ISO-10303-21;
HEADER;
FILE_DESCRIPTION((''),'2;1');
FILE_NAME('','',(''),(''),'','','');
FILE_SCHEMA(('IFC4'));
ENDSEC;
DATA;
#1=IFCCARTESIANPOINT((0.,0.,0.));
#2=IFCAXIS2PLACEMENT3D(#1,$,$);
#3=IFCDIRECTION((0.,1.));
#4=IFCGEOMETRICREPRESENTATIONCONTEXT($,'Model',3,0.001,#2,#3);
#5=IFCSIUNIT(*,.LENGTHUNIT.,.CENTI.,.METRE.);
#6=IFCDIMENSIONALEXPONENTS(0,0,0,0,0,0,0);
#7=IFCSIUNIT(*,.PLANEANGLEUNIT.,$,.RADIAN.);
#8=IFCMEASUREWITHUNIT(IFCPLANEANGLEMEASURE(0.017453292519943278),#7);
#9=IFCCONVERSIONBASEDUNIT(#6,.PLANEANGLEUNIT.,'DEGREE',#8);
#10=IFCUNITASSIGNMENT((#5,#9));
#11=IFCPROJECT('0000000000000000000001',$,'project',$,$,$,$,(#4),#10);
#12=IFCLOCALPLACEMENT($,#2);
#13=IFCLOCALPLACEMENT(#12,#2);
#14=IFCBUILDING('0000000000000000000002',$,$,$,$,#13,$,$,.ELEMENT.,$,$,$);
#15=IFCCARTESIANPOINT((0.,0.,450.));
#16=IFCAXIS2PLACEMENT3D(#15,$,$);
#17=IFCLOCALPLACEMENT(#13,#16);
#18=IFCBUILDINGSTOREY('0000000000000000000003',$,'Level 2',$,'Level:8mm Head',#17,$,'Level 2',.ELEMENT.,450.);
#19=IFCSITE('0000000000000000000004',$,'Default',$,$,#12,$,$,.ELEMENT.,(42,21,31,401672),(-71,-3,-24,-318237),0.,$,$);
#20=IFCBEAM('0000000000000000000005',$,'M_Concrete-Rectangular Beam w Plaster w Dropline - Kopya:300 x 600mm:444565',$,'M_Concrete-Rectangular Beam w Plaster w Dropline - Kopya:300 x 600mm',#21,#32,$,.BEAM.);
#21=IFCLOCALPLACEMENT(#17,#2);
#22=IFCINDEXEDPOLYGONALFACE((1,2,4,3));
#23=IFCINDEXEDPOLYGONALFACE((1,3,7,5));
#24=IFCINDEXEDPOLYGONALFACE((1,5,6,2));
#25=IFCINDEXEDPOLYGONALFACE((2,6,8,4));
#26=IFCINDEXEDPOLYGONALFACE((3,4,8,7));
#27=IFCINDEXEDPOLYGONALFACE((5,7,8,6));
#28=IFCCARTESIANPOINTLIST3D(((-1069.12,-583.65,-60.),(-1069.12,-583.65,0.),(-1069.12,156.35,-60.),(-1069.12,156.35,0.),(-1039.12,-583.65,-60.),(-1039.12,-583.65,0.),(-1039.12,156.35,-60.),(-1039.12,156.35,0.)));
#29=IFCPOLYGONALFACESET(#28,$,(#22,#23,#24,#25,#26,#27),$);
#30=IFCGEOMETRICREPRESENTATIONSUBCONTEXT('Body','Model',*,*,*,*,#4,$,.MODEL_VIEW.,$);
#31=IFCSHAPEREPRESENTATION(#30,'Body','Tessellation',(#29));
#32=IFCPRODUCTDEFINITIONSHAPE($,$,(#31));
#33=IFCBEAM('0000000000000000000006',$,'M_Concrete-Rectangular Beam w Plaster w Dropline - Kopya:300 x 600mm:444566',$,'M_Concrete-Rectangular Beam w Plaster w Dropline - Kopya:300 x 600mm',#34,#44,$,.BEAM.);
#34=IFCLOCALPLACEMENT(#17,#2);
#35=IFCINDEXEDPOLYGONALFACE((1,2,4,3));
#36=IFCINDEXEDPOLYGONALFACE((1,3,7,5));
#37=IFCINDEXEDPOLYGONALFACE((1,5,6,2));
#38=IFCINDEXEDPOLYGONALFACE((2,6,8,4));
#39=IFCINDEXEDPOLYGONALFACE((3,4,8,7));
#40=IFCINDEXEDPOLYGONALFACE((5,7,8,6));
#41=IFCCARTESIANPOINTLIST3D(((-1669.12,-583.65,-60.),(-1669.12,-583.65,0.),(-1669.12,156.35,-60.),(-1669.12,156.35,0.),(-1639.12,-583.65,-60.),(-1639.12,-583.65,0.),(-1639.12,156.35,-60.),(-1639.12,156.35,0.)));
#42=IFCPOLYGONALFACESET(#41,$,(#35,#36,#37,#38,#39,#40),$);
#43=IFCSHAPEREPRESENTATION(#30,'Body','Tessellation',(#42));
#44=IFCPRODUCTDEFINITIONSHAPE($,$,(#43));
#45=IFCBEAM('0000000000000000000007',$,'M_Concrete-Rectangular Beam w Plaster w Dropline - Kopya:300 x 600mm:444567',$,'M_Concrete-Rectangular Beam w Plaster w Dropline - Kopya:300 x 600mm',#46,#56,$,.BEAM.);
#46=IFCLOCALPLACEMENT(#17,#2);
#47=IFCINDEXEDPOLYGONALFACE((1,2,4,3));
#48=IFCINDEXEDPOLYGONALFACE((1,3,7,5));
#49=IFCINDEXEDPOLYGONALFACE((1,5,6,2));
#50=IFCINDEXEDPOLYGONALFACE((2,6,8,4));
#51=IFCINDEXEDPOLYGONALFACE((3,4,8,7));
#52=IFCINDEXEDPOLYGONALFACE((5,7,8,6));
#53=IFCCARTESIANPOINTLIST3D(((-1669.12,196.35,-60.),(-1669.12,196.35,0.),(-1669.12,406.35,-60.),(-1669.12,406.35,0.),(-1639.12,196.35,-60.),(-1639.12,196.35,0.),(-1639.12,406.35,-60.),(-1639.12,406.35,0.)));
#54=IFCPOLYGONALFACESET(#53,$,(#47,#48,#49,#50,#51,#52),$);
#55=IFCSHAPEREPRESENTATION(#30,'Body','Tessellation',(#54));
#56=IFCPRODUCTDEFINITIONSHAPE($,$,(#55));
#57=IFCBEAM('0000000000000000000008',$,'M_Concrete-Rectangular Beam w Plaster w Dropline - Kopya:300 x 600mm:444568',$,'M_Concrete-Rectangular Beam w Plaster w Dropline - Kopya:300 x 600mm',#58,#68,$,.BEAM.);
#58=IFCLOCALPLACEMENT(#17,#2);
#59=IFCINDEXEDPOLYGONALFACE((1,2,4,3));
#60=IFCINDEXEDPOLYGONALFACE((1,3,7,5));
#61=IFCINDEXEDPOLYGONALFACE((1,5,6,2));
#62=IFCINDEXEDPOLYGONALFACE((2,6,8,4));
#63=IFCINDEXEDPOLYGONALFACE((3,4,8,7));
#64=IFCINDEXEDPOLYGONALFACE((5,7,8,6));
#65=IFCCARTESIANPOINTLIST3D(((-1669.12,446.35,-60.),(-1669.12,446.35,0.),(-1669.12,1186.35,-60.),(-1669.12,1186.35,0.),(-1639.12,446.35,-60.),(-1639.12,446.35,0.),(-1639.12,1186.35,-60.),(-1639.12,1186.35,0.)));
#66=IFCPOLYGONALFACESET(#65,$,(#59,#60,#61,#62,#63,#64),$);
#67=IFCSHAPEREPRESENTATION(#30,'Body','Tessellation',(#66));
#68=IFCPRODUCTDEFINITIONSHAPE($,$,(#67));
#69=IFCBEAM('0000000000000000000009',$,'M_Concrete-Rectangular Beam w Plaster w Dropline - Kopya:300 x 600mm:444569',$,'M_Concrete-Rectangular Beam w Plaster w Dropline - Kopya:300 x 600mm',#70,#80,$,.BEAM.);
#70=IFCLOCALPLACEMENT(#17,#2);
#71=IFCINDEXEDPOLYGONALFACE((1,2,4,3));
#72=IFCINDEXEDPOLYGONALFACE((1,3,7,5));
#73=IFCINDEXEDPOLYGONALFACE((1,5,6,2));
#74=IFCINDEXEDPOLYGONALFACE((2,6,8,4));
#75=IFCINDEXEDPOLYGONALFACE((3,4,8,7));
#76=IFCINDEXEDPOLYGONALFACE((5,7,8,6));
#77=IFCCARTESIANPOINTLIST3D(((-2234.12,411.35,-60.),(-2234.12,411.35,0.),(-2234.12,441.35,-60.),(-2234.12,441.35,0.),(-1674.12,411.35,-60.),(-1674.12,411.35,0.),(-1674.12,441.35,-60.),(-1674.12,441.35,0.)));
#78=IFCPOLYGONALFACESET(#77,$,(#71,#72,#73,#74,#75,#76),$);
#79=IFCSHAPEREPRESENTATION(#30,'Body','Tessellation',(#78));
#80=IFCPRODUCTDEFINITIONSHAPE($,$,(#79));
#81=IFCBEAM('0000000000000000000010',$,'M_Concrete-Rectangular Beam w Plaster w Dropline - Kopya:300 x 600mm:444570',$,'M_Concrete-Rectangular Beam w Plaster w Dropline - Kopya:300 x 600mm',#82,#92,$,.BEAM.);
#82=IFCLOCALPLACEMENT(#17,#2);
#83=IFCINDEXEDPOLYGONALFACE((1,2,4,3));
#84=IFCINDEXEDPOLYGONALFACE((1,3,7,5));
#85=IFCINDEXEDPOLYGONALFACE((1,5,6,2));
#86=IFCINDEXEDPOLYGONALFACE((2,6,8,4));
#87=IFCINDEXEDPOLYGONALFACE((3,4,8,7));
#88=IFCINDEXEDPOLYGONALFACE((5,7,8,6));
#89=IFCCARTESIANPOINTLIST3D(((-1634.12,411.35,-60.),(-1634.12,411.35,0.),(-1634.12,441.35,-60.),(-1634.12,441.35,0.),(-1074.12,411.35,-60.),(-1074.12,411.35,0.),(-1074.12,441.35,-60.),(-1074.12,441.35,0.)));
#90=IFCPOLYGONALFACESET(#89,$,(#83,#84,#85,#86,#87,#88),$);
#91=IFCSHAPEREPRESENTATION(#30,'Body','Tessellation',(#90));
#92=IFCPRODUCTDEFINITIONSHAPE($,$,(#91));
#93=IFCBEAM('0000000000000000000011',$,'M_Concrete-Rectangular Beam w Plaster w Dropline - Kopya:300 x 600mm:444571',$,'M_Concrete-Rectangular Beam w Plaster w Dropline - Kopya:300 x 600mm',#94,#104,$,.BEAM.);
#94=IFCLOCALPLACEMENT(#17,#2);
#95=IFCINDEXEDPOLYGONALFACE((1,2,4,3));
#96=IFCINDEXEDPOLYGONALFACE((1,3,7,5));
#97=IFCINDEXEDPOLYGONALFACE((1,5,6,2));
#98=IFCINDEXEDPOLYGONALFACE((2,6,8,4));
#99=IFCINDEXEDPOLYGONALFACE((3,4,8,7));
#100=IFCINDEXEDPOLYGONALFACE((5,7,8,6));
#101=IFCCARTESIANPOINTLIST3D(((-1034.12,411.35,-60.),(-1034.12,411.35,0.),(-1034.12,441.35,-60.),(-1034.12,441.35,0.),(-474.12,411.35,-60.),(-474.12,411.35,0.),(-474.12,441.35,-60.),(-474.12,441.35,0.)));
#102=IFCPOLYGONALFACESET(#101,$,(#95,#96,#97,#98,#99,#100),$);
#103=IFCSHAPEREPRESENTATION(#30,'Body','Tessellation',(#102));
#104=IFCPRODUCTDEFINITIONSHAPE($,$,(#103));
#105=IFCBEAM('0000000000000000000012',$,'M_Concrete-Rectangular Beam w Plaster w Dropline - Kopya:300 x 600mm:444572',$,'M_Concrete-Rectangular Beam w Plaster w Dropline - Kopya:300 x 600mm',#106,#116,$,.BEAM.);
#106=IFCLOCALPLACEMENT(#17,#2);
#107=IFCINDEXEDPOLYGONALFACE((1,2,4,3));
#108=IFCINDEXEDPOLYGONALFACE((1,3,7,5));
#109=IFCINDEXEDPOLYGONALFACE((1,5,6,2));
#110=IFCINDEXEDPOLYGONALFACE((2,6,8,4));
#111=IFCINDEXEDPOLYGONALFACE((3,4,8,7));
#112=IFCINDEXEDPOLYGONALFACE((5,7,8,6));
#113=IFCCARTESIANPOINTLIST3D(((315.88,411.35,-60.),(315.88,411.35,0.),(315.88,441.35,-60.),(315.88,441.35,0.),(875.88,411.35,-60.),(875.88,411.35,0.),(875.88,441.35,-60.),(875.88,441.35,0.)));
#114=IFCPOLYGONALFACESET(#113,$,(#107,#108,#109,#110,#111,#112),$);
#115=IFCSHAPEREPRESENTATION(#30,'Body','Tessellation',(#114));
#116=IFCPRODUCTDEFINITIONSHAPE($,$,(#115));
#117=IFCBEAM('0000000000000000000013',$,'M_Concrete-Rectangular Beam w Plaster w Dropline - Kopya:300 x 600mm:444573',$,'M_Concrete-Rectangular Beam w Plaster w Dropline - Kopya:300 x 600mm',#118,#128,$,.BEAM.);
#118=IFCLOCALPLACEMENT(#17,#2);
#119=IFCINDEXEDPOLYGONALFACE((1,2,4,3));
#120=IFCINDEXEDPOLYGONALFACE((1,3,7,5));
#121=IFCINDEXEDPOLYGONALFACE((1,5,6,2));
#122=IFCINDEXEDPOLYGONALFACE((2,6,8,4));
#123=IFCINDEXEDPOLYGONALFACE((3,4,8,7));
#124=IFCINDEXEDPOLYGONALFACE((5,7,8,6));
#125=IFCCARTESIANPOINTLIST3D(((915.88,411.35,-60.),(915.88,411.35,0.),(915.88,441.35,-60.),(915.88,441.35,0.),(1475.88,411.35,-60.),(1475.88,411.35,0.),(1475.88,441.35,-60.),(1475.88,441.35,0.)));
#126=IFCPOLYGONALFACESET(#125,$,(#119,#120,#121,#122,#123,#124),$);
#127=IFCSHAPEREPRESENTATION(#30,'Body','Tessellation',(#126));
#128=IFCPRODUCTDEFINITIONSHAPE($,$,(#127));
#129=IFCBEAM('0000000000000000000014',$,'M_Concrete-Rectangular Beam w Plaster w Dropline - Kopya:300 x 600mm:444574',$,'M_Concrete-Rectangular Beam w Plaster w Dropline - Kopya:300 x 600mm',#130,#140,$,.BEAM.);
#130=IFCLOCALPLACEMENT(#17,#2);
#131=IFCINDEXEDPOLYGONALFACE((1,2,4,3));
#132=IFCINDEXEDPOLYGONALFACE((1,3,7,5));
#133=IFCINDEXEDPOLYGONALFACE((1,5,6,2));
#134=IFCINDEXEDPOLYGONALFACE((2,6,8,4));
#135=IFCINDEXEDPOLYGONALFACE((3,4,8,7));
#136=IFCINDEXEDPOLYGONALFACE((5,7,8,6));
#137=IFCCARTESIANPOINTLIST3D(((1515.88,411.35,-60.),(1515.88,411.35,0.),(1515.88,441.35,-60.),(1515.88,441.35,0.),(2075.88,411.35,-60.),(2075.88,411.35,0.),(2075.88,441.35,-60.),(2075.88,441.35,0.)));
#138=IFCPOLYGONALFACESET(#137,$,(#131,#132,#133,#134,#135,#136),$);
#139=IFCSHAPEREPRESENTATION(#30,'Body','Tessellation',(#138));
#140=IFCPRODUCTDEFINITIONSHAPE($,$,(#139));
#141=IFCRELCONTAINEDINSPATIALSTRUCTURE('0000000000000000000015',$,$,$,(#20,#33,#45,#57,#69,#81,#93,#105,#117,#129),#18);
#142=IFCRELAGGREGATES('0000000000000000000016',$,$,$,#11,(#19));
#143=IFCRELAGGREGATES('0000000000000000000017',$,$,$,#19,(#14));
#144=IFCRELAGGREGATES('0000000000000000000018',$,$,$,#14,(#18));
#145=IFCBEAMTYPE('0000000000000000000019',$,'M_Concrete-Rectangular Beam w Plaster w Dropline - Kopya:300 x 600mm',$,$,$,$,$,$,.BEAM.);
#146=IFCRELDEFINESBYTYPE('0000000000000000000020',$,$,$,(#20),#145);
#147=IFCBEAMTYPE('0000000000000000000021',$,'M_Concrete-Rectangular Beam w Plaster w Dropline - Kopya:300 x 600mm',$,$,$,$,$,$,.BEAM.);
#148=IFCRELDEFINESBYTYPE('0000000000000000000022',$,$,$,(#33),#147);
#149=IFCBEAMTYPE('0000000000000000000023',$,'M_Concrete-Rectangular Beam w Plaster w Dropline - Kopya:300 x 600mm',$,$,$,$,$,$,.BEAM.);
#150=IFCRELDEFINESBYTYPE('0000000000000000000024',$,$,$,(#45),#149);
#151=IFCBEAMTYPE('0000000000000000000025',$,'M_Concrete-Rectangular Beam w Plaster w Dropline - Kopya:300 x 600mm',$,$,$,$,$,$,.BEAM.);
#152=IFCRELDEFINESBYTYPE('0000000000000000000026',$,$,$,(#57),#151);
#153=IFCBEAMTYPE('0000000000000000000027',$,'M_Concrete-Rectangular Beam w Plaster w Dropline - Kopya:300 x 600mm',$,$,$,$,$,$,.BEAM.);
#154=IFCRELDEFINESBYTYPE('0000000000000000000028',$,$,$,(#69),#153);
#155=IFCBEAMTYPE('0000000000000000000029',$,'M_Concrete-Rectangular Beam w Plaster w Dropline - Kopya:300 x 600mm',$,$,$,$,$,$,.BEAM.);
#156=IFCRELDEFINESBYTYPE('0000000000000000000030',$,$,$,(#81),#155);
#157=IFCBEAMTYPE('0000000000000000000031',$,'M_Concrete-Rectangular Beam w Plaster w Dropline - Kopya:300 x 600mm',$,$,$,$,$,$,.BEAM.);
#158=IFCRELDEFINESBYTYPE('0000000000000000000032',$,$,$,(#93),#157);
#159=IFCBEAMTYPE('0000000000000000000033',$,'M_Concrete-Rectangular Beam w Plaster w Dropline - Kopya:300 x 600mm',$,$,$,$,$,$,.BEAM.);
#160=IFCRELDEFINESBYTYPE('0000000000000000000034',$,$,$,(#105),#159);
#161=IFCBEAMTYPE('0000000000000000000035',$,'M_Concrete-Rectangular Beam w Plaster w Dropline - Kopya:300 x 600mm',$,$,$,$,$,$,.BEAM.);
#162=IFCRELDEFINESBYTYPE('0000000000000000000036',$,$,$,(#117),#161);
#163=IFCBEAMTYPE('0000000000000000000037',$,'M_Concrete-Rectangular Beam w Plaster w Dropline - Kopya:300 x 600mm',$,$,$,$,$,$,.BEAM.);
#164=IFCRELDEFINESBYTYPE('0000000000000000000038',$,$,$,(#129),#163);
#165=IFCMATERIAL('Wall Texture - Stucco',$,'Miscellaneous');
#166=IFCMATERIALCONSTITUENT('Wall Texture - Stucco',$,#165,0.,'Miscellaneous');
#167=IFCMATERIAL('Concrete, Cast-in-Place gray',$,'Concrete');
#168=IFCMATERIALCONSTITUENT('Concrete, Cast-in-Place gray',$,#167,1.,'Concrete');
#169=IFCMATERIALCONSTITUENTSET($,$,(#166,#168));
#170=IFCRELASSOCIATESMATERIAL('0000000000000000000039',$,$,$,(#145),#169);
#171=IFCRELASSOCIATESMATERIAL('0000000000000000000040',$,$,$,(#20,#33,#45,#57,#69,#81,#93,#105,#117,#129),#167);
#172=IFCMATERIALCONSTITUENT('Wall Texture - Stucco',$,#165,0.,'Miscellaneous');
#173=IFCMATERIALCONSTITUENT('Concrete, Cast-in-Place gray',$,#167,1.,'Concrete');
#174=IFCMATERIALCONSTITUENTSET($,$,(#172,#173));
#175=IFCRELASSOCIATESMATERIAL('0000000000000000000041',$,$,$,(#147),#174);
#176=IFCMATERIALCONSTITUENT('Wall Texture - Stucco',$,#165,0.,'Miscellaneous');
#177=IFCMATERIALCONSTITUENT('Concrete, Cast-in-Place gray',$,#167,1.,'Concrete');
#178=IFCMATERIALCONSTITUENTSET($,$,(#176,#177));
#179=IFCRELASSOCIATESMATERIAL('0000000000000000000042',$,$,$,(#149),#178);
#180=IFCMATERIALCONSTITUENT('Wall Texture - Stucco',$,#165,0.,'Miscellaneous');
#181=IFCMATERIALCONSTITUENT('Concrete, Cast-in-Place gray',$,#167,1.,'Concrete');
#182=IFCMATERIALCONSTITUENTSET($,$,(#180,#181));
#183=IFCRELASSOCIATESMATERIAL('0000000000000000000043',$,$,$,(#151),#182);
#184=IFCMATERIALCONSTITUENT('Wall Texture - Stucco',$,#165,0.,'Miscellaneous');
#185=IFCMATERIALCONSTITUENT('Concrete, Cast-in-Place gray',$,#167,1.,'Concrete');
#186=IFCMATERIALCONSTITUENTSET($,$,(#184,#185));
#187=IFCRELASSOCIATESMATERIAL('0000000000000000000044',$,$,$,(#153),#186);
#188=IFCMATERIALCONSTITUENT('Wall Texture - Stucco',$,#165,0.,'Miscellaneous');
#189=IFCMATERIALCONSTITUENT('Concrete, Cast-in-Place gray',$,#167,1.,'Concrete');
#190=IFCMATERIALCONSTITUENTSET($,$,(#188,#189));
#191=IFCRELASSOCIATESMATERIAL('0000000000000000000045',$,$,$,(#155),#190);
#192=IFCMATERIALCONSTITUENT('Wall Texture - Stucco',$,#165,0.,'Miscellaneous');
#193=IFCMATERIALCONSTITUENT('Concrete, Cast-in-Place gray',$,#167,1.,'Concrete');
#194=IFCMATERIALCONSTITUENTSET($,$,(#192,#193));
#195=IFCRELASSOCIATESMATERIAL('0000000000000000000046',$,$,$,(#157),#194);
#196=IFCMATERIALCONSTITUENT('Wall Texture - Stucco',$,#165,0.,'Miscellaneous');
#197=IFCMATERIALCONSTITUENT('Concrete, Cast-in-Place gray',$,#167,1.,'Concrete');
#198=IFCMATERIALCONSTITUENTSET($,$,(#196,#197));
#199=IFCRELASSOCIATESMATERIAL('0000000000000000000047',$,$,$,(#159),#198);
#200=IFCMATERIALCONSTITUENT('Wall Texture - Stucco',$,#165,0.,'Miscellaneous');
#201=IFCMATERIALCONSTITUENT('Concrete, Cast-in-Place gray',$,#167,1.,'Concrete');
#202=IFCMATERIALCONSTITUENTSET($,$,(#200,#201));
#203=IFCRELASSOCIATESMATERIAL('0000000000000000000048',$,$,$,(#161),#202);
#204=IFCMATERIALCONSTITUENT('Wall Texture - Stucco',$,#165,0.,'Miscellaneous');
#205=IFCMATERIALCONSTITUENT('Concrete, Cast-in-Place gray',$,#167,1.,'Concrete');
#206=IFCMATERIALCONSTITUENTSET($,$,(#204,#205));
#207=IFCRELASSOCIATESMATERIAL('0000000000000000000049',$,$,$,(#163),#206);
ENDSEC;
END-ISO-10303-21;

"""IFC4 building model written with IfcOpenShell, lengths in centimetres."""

from ifc_helpers import new_model, entity, si_unit, converted_unit, direction, frame, origin, place, context, subcontext, project, spatial, indexed_curve, outline, extrude, source, transform, mapped, material, constituent, constituent_set, type_object, type_shapes, element, save


model = new_model("IFC4")

# Units and contexts
model_context = context("Model", 3, precision=0.001, world=origin(), true_north=direction((0.0, 1.0)))
body_context = subcontext(model_context, "Body", "Model", "MODEL_VIEW")
ifc_project = project(units=[si_unit("LENGTHUNIT", "METRE", prefix="CENTI"), converted_unit("PLANEANGLEUNIT", "DEGREE", entity("IfcPlaneAngleMeasure", 0.017453292519943278), si_unit("PLANEANGLEUNIT", "RADIAN"), dimensions=[0, 0, 0, 0, 0, 0, 0])], contexts=[model_context])

# Site, building, storey
site_placement = place(None, origin())
site = spatial("IfcSite", under=ifc_project, at=site_placement, Name="Default", CompositionType="ELEMENT", RefLatitude=(42, 21, 31, 401672), RefLongitude=(-71, -3, -24, -318237), RefElevation=0.0)
building_placement = place(site_placement, origin())
building = spatial("IfcBuilding", under=site, at=building_placement, CompositionType="ELEMENT")
storey_placement = place(building_placement, frame((0.0, 0.0, 450.0)))
storey = spatial("IfcBuildingStorey", under=building, at=storey_placement, Name="Level 2", ObjectType="Level:8mm Head", LongName="Level 2", CompositionType="ELEMENT", Elevation=450.0)

# Beams
ifc_material_1 = material(Name="Concrete, Cast-in-Place gray", Category="Concrete")
ifc_material_2 = material(Name="Wall Texture - Stucco", Category="Miscellaneous")
ifc_constituent_1 = constituent(ifc_material_2, Name="Wall Texture - Stucco", Category="Miscellaneous", fraction=0.0)
ifc_constituent_2 = constituent(ifc_material_1, Name="Concrete, Cast-in-Place gray", Category="Concrete", fraction=1.0)
ifc_constituent_set_1 = constituent_set(constituents=[ifc_constituent_1, ifc_constituent_2])
beam_type_1 = type_object("IfcBeamType", Name="M_Concrete-Rectangular Beam w Plaster w Dropline - Kopya:300 x 600mm", PredefinedType="BEAM", material=ifc_constituent_set_1)
shared_shape_1 = source(origin(), body_context, "Body", "SweptSolid", [
    extrude(outline(indexed_curve([(-15.0, -30.0), (15.0, -30.0), (15.0, 30.0), (-15.0, 30.0), (-15.0, -30.0)], self_intersect=False)), frame((-1054.12, 156.35, 420.0), z_axis=(0.0, -1.0, 0.0), x_axis=(-1.0, 0.0, 0.0)), (0.0, 0.0, 1.0), 740.0),
])
type_shapes(beam_type_1, [shared_shape_1])
beam_1_placement = place(storey_placement, frame((0.0, 0.0, -450.0)))
element("IfcBeam", 1, at=beam_1_placement, inside=storey, type_object=beam_type_1, material=ifc_material_1, Name="M_Concrete-Rectangular Beam w Plaster w Dropline - Kopya:300 x 600mm:444565", ObjectType="M_Concrete-Rectangular Beam w Plaster w Dropline - Kopya:300 x 600mm", PredefinedType="BEAM", context=body_context, shape_type="MappedRepresentation", body=[
    mapped(shared_shape_1, transform((0.0, 0.0, 0.0), scale=1.0)),
])
ifc_constituent_3 = constituent(ifc_material_2, Name="Wall Texture - Stucco", Category="Miscellaneous", fraction=0.0)
ifc_constituent_4 = constituent(ifc_material_1, Name="Concrete, Cast-in-Place gray", Category="Concrete", fraction=1.0)
ifc_constituent_set_2 = constituent_set(constituents=[ifc_constituent_3, ifc_constituent_4])
beam_type_2 = type_object("IfcBeamType", Name="M_Concrete-Rectangular Beam w Plaster w Dropline - Kopya:300 x 600mm", PredefinedType="BEAM", material=ifc_constituent_set_2)
shared_shape_2 = source(origin(), body_context, "Body", "SweptSolid", [
    extrude(outline(indexed_curve([(-15.0, -30.0), (15.0, -30.0), (15.0, 30.0), (-15.0, 30.0), (-15.0, -30.0)], self_intersect=False)), frame((-1654.12, -583.65, 420.0), z_axis=(0.0, 1.0, 0.0), x_axis=(-1.0, 0.0, 0.0)), (0.0, 0.0, 1.0), 740.0),
])
type_shapes(beam_type_2, [shared_shape_2])
beam_2_placement = place(storey_placement, frame((0.0, 0.0, -450.0)))
element("IfcBeam", 2, at=beam_2_placement, inside=storey, type_object=beam_type_2, material=ifc_material_1, Name="M_Concrete-Rectangular Beam w Plaster w Dropline - Kopya:300 x 600mm:444566", ObjectType="M_Concrete-Rectangular Beam w Plaster w Dropline - Kopya:300 x 600mm", PredefinedType="BEAM", context=body_context, shape_type="MappedRepresentation", body=[
    mapped(shared_shape_2, transform((0.0, 0.0, 0.0), scale=1.0)),
])
ifc_constituent_5 = constituent(ifc_material_2, Name="Wall Texture - Stucco", Category="Miscellaneous", fraction=0.0)
ifc_constituent_6 = constituent(ifc_material_1, Name="Concrete, Cast-in-Place gray", Category="Concrete", fraction=1.0)
ifc_constituent_set_3 = constituent_set(constituents=[ifc_constituent_5, ifc_constituent_6])
beam_type_3 = type_object("IfcBeamType", Name="M_Concrete-Rectangular Beam w Plaster w Dropline - Kopya:300 x 600mm", PredefinedType="BEAM", material=ifc_constituent_set_3)
shared_shape_3 = source(origin(), body_context, "Body", "SweptSolid", [
    extrude(outline(indexed_curve([(-15.0, -30.0), (15.0, -30.0), (15.0, 30.0), (-15.0, 30.0), (-15.0, -30.0)], self_intersect=False)), frame((-1654.12, 196.35, 420.0), z_axis=(0.0, 1.0, 0.0), x_axis=(-1.0, 0.0, 0.0)), (0.0, 0.0, 1.0), 210.0),
])
type_shapes(beam_type_3, [shared_shape_3])
beam_3_placement = place(storey_placement, frame((0.0, 0.0, -450.0)))
element("IfcBeam", 3, at=beam_3_placement, inside=storey, type_object=beam_type_3, material=ifc_material_1, Name="M_Concrete-Rectangular Beam w Plaster w Dropline - Kopya:300 x 600mm:444567", ObjectType="M_Concrete-Rectangular Beam w Plaster w Dropline - Kopya:300 x 600mm", PredefinedType="BEAM", context=body_context, shape_type="MappedRepresentation", body=[
    mapped(shared_shape_3, transform((0.0, 0.0, 0.0), scale=1.0)),
])
ifc_constituent_7 = constituent(ifc_material_2, Name="Wall Texture - Stucco", Category="Miscellaneous", fraction=0.0)
ifc_constituent_8 = constituent(ifc_material_1, Name="Concrete, Cast-in-Place gray", Category="Concrete", fraction=1.0)
ifc_constituent_set_4 = constituent_set(constituents=[ifc_constituent_7, ifc_constituent_8])
beam_type_4 = type_object("IfcBeamType", Name="M_Concrete-Rectangular Beam w Plaster w Dropline - Kopya:300 x 600mm", PredefinedType="BEAM", material=ifc_constituent_set_4)
shared_shape_4 = source(origin(), body_context, "Body", "SweptSolid", [
    extrude(outline(indexed_curve([(-15.0, -30.0), (15.0, -30.0), (15.0, 30.0), (-15.0, 30.0), (-15.0, -30.0)], self_intersect=False)), frame((-1654.12, 446.35, 420.0), z_axis=(0.0, 1.0, 0.0), x_axis=(-1.0, 0.0, 0.0)), (0.0, 0.0, 1.0), 740.0),
])
type_shapes(beam_type_4, [shared_shape_4])
beam_4_placement = place(storey_placement, frame((0.0, 0.0, -450.0)))
element("IfcBeam", 4, at=beam_4_placement, inside=storey, type_object=beam_type_4, material=ifc_material_1, Name="M_Concrete-Rectangular Beam w Plaster w Dropline - Kopya:300 x 600mm:444568", ObjectType="M_Concrete-Rectangular Beam w Plaster w Dropline - Kopya:300 x 600mm", PredefinedType="BEAM", context=body_context, shape_type="MappedRepresentation", body=[
    mapped(shared_shape_4, transform((0.0, 0.0, 0.0), scale=1.0)),
])
ifc_constituent_9 = constituent(ifc_material_2, Name="Wall Texture - Stucco", Category="Miscellaneous", fraction=0.0)
ifc_constituent_10 = constituent(ifc_material_1, Name="Concrete, Cast-in-Place gray", Category="Concrete", fraction=1.0)
ifc_constituent_set_5 = constituent_set(constituents=[ifc_constituent_9, ifc_constituent_10])
beam_type_5 = type_object("IfcBeamType", Name="M_Concrete-Rectangular Beam w Plaster w Dropline - Kopya:300 x 600mm", PredefinedType="BEAM", material=ifc_constituent_set_5)
shared_shape_5 = source(origin(), body_context, "Body", "SweptSolid", [
    extrude(outline(indexed_curve([(-30.0, -15.0), (30.0, -15.0), (30.0, 15.0), (-30.0, 15.0), (-30.0, -15.0)], self_intersect=False)), frame((-2234.12, 426.35, 420.0), z_axis=(1.0, 0.0, 0.0), x_axis=(0.0, 0.0, -1.0)), (0.0, 0.0, 1.0), 560.0),
])
type_shapes(beam_type_5, [shared_shape_5])
beam_5_placement = place(storey_placement, frame((0.0, 0.0, -450.0)))
element("IfcBeam", 5, at=beam_5_placement, inside=storey, type_object=beam_type_5, material=ifc_material_1, Name="M_Concrete-Rectangular Beam w Plaster w Dropline - Kopya:300 x 600mm:444569", ObjectType="M_Concrete-Rectangular Beam w Plaster w Dropline - Kopya:300 x 600mm", PredefinedType="BEAM", context=body_context, shape_type="MappedRepresentation", body=[
    mapped(shared_shape_5, transform((0.0, 0.0, 0.0), scale=1.0)),
])
ifc_constituent_11 = constituent(ifc_material_2, Name="Wall Texture - Stucco", Category="Miscellaneous", fraction=0.0)
ifc_constituent_12 = constituent(ifc_material_1, Name="Concrete, Cast-in-Place gray", Category="Concrete", fraction=1.0)
ifc_constituent_set_6 = constituent_set(constituents=[ifc_constituent_11, ifc_constituent_12])
beam_type_6 = type_object("IfcBeamType", Name="M_Concrete-Rectangular Beam w Plaster w Dropline - Kopya:300 x 600mm", PredefinedType="BEAM", material=ifc_constituent_set_6)
shared_shape_6 = source(origin(), body_context, "Body", "SweptSolid", [
    extrude(outline(indexed_curve([(-30.0, -15.0), (30.0, -15.0), (30.0, 15.0), (-30.0, 15.0), (-30.0, -15.0)], self_intersect=False)), frame((-1634.12, 426.35, 420.0), z_axis=(1.0, 0.0, 0.0), x_axis=(0.0, 0.0, -1.0)), (0.0, 0.0, 1.0), 560.0),
])
type_shapes(beam_type_6, [shared_shape_6])
beam_6_placement = place(storey_placement, frame((0.0, 0.0, -450.0)))
element("IfcBeam", 6, at=beam_6_placement, inside=storey, type_object=beam_type_6, material=ifc_material_1, Name="M_Concrete-Rectangular Beam w Plaster w Dropline - Kopya:300 x 600mm:444570", ObjectType="M_Concrete-Rectangular Beam w Plaster w Dropline - Kopya:300 x 600mm", PredefinedType="BEAM", context=body_context, shape_type="MappedRepresentation", body=[
    mapped(shared_shape_6, transform((0.0, 0.0, 0.0), scale=1.0)),
])
ifc_constituent_13 = constituent(ifc_material_2, Name="Wall Texture - Stucco", Category="Miscellaneous", fraction=0.0)
ifc_constituent_14 = constituent(ifc_material_1, Name="Concrete, Cast-in-Place gray", Category="Concrete", fraction=1.0)
ifc_constituent_set_7 = constituent_set(constituents=[ifc_constituent_13, ifc_constituent_14])
beam_type_7 = type_object("IfcBeamType", Name="M_Concrete-Rectangular Beam w Plaster w Dropline - Kopya:300 x 600mm", PredefinedType="BEAM", material=ifc_constituent_set_7)
shared_shape_7 = source(origin(), body_context, "Body", "SweptSolid", [
    extrude(outline(indexed_curve([(-30.0, -15.0), (30.0, -15.0), (30.0, 15.0), (-30.0, 15.0), (-30.0, -15.0)], self_intersect=False)), frame((-1034.12, 426.35, 420.0), z_axis=(1.0, 0.0, 0.0), x_axis=(0.0, 0.0, -1.0)), (0.0, 0.0, 1.0), 560.0),
])
type_shapes(beam_type_7, [shared_shape_7])
beam_7_placement = place(storey_placement, frame((0.0, 0.0, -450.0)))
element("IfcBeam", 7, at=beam_7_placement, inside=storey, type_object=beam_type_7, material=ifc_material_1, Name="M_Concrete-Rectangular Beam w Plaster w Dropline - Kopya:300 x 600mm:444571", ObjectType="M_Concrete-Rectangular Beam w Plaster w Dropline - Kopya:300 x 600mm", PredefinedType="BEAM", context=body_context, shape_type="MappedRepresentation", body=[
    mapped(shared_shape_7, transform((0.0, 0.0, 0.0), scale=1.0)),
])
ifc_constituent_15 = constituent(ifc_material_2, Name="Wall Texture - Stucco", Category="Miscellaneous", fraction=0.0)
ifc_constituent_16 = constituent(ifc_material_1, Name="Concrete, Cast-in-Place gray", Category="Concrete", fraction=1.0)
ifc_constituent_set_8 = constituent_set(constituents=[ifc_constituent_15, ifc_constituent_16])
beam_type_8 = type_object("IfcBeamType", Name="M_Concrete-Rectangular Beam w Plaster w Dropline - Kopya:300 x 600mm", PredefinedType="BEAM", material=ifc_constituent_set_8)
shared_shape_8 = source(origin(), body_context, "Body", "SweptSolid", [
    extrude(outline(indexed_curve([(-30.0, -15.0), (30.0, -15.0), (30.0, 15.0), (-30.0, 15.0), (-30.0, -15.0)], self_intersect=False)), frame((315.88, 426.35, 420.0), z_axis=(1.0, 0.0, 0.0), x_axis=(0.0, 0.0, -1.0)), (0.0, 0.0, 1.0), 560.0),
])
type_shapes(beam_type_8, [shared_shape_8])
beam_8_placement = place(storey_placement, frame((0.0, 0.0, -450.0)))
element("IfcBeam", 8, at=beam_8_placement, inside=storey, type_object=beam_type_8, material=ifc_material_1, Name="M_Concrete-Rectangular Beam w Plaster w Dropline - Kopya:300 x 600mm:444572", ObjectType="M_Concrete-Rectangular Beam w Plaster w Dropline - Kopya:300 x 600mm", PredefinedType="BEAM", context=body_context, shape_type="MappedRepresentation", body=[
    mapped(shared_shape_8, transform((0.0, 0.0, 0.0), scale=1.0)),
])
ifc_constituent_17 = constituent(ifc_material_2, Name="Wall Texture - Stucco", Category="Miscellaneous", fraction=0.0)
ifc_constituent_18 = constituent(ifc_material_1, Name="Concrete, Cast-in-Place gray", Category="Concrete", fraction=1.0)
ifc_constituent_set_9 = constituent_set(constituents=[ifc_constituent_17, ifc_constituent_18])
beam_type_9 = type_object("IfcBeamType", Name="M_Concrete-Rectangular Beam w Plaster w Dropline - Kopya:300 x 600mm", PredefinedType="BEAM", material=ifc_constituent_set_9)
shared_shape_9 = source(origin(), body_context, "Body", "SweptSolid", [
    extrude(outline(indexed_curve([(-30.0, -15.0), (30.0, -15.0), (30.0, 15.0), (-30.0, 15.0), (-30.0, -15.0)], self_intersect=False)), frame((915.88, 426.35, 420.0), z_axis=(1.0, 0.0, 0.0), x_axis=(0.0, 0.0, -1.0)), (0.0, 0.0, 1.0), 560.0),
])
type_shapes(beam_type_9, [shared_shape_9])
beam_9_placement = place(storey_placement, frame((0.0, 0.0, -450.0)))
element("IfcBeam", 9, at=beam_9_placement, inside=storey, type_object=beam_type_9, material=ifc_material_1, Name="M_Concrete-Rectangular Beam w Plaster w Dropline - Kopya:300 x 600mm:444573", ObjectType="M_Concrete-Rectangular Beam w Plaster w Dropline - Kopya:300 x 600mm", PredefinedType="BEAM", context=body_context, shape_type="MappedRepresentation", body=[
    mapped(shared_shape_9, transform((0.0, 0.0, 0.0), scale=1.0)),
])
ifc_constituent_19 = constituent(ifc_material_2, Name="Wall Texture - Stucco", Category="Miscellaneous", fraction=0.0)
ifc_constituent_20 = constituent(ifc_material_1, Name="Concrete, Cast-in-Place gray", Category="Concrete", fraction=1.0)
ifc_constituent_set_10 = constituent_set(constituents=[ifc_constituent_19, ifc_constituent_20])
beam_type_10 = type_object("IfcBeamType", Name="M_Concrete-Rectangular Beam w Plaster w Dropline - Kopya:300 x 600mm", PredefinedType="BEAM", material=ifc_constituent_set_10)
shared_shape_10 = source(origin(), body_context, "Body", "SweptSolid", [
    extrude(outline(indexed_curve([(-30.0, -15.0), (30.0, -15.0), (30.0, 15.0), (-30.0, 15.0), (-30.0, -15.0)], self_intersect=False)), frame((1515.88, 426.35, 420.0), z_axis=(1.0, 0.0, 0.0), x_axis=(0.0, 0.0, -1.0)), (0.0, 0.0, 1.0), 560.0),
])
type_shapes(beam_type_10, [shared_shape_10])
beam_10_placement = place(storey_placement, frame((0.0, 0.0, -450.0)))
element("IfcBeam", 10, at=beam_10_placement, inside=storey, type_object=beam_type_10, material=ifc_material_1, Name="M_Concrete-Rectangular Beam w Plaster w Dropline - Kopya:300 x 600mm:444574", ObjectType="M_Concrete-Rectangular Beam w Plaster w Dropline - Kopya:300 x 600mm", PredefinedType="BEAM", context=body_context, shape_type="MappedRepresentation", body=[
    mapped(shared_shape_10, transform((0.0, 0.0, 0.0), scale=1.0)),
])

save(model, "model.ifc")
